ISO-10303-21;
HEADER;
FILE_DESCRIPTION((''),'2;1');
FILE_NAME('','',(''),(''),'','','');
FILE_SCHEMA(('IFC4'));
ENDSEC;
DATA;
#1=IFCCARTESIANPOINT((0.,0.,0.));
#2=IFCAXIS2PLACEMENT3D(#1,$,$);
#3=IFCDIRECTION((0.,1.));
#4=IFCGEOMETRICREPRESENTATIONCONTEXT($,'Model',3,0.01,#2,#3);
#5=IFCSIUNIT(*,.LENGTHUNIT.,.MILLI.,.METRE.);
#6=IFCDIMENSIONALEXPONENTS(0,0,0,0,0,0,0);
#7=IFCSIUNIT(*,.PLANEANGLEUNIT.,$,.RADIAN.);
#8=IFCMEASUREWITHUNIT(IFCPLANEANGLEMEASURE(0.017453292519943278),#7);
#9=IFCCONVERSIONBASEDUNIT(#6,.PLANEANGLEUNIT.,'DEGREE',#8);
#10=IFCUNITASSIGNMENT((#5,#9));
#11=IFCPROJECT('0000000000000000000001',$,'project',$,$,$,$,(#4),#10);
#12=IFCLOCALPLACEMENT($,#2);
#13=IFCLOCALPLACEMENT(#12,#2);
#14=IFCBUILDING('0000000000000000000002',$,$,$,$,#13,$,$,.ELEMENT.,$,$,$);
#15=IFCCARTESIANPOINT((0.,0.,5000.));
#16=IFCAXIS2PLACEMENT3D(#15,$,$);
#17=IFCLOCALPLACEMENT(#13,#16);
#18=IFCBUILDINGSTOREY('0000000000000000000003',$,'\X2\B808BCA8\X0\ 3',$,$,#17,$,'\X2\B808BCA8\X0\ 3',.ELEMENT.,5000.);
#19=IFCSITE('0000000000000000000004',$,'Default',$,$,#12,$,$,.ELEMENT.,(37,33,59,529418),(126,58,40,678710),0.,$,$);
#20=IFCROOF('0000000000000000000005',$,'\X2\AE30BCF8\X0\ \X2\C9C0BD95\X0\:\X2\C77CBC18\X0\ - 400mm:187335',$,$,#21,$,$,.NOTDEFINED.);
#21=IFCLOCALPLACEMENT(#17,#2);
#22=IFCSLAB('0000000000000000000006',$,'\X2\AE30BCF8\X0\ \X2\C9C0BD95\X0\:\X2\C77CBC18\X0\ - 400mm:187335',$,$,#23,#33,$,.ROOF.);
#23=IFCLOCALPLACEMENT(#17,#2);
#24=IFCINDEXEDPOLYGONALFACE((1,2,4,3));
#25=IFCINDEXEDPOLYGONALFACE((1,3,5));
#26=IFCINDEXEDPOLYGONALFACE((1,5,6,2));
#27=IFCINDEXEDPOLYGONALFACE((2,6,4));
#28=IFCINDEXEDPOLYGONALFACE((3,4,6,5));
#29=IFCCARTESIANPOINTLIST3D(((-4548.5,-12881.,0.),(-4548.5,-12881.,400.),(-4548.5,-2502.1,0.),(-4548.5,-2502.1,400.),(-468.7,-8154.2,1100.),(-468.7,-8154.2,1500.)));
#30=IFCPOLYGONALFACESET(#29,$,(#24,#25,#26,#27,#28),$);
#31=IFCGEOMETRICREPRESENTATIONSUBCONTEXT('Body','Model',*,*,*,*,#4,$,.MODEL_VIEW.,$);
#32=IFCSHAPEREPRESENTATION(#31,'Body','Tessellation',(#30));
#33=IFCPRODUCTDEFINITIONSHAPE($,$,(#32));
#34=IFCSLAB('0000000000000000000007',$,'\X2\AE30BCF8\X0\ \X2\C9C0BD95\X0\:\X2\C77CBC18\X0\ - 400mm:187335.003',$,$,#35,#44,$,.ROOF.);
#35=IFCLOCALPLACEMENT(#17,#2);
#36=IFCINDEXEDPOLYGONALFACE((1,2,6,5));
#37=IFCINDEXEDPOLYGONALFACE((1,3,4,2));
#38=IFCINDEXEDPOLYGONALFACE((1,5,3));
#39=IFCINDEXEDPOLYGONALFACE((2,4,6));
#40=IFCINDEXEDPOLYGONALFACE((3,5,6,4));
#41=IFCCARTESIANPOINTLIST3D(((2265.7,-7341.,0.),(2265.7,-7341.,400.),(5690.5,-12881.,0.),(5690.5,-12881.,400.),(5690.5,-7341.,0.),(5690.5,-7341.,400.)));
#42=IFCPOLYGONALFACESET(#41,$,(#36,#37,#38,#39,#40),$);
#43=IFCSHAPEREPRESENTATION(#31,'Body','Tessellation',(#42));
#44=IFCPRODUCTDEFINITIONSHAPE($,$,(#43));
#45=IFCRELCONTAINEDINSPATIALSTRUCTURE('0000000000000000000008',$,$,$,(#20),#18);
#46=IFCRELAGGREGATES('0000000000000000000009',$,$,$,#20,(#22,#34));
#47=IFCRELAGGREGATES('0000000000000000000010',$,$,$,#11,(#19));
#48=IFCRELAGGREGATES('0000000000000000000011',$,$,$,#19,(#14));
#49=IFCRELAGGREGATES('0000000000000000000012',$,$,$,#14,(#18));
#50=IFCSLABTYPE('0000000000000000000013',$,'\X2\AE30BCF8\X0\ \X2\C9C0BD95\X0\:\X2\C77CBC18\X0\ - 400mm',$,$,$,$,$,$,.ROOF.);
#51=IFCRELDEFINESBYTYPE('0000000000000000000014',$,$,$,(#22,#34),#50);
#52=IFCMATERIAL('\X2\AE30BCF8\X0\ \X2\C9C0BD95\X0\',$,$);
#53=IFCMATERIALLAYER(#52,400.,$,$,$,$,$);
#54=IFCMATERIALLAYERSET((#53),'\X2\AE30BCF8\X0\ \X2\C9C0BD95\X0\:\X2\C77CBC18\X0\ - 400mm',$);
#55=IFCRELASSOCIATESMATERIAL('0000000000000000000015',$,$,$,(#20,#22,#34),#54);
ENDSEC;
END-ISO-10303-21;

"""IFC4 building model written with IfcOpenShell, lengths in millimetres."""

from ifc_helpers import new_model, entity, si_unit, converted_unit, direction, frame, origin, place, context, subcontext, project, spatial, polyline, outline, extrude, material, layer, layer_set, type_object, element, aggregate, save


model = new_model("IFC4")

# Units and contexts
model_context = context("Model", 3, precision=0.01, world=origin(), true_north=direction((0.0, 1.0)))
body_context = subcontext(model_context, "Body", "Model", "MODEL_VIEW")
ifc_project = project(units=[si_unit("LENGTHUNIT", "METRE", prefix="MILLI"), converted_unit("PLANEANGLEUNIT", "DEGREE", entity("IfcPlaneAngleMeasure", 0.017453292519943278), si_unit("PLANEANGLEUNIT", "RADIAN"), dimensions=[0, 0, 0, 0, 0, 0, 0])], contexts=[model_context])

# Site, building, storey
site_placement = place(None, origin())
site = spatial("IfcSite", under=ifc_project, at=site_placement, Name="Default", CompositionType="ELEMENT", RefLatitude=(37, 33, 59, 529418), RefLongitude=(126, 58, 40, 678710), RefElevation=0.0)
building_placement = place(site_placement, origin())
building = spatial("IfcBuilding", under=site, at=building_placement, CompositionType="ELEMENT")
storey_placement = place(building_placement, frame((0.0, 0.0, 5000.0)))
storey = spatial("IfcBuildingStorey", under=building, at=storey_placement, Name="레벨 3", LongName="레벨 3", CompositionType="ELEMENT", Elevation=5000.0)

# Roof, slabs
ifc_material = material(Name="기본 지붕")
ifc_layer = layer(ifc_material, 400.0)
ifc_layer_set = layer_set([ifc_layer], Name="기본 지붕:일반 - 400mm")
roof_placement = place(storey_placement, frame((-4548.5, -12881.0, 0.0)))
roof = element("IfcRoof", 1, at=roof_placement, inside=storey, material=ifc_layer_set, Name="기본 지붕:일반 - 400mm:187335", PredefinedType="NOTDEFINED")
slab_type = type_object("IfcSlabType", Name="기본 지붕:일반 - 400mm", PredefinedType="ROOF")
slab_1_placement = place(roof_placement, origin())
slab_1 = element("IfcSlab", 2, at=slab_1_placement, type_object=slab_type, material=ifc_layer_set, Name="기본 지붕:일반 - 400mm:187335", PredefinedType="ROOF", context=body_context, shape_type="SweptSolid", body=[
    extrude(outline(polyline([(-2112.7, 5189.4), (-2112.7, -5189.4), (2112.7, -462.7), (-2112.7, 5189.4)])), frame((2039.9, 5189.4, 550.0), z_axis=(-0.260328, 0.0, 0.96552), x_axis=(0.96552, 0.0, 0.260328)), (0.260328, 0.0, 0.96552), 400.0),
])
slab_2_placement = place(roof_placement, origin())
slab_2 = element("IfcSlab", 3, at=slab_2_placement, type_object=slab_type, material=ifc_layer_set, Name="기본 지붕:일반 - 400mm:187335.003", PredefinedType="ROOF", context=body_context, shape_type="SweptSolid", body=[
    extrude(outline(polyline([(1712.4, -2770.0), (1712.4, 2770.0), (-1712.4, 2770.0), (1712.4, -2770.0)])), frame((8526.6, 2770.0, 0.0)), (0.0, 0.0, 1.0), 400.0),
])
aggregate(roof, [slab_1, slab_2])

save(model, "model.ifc")
